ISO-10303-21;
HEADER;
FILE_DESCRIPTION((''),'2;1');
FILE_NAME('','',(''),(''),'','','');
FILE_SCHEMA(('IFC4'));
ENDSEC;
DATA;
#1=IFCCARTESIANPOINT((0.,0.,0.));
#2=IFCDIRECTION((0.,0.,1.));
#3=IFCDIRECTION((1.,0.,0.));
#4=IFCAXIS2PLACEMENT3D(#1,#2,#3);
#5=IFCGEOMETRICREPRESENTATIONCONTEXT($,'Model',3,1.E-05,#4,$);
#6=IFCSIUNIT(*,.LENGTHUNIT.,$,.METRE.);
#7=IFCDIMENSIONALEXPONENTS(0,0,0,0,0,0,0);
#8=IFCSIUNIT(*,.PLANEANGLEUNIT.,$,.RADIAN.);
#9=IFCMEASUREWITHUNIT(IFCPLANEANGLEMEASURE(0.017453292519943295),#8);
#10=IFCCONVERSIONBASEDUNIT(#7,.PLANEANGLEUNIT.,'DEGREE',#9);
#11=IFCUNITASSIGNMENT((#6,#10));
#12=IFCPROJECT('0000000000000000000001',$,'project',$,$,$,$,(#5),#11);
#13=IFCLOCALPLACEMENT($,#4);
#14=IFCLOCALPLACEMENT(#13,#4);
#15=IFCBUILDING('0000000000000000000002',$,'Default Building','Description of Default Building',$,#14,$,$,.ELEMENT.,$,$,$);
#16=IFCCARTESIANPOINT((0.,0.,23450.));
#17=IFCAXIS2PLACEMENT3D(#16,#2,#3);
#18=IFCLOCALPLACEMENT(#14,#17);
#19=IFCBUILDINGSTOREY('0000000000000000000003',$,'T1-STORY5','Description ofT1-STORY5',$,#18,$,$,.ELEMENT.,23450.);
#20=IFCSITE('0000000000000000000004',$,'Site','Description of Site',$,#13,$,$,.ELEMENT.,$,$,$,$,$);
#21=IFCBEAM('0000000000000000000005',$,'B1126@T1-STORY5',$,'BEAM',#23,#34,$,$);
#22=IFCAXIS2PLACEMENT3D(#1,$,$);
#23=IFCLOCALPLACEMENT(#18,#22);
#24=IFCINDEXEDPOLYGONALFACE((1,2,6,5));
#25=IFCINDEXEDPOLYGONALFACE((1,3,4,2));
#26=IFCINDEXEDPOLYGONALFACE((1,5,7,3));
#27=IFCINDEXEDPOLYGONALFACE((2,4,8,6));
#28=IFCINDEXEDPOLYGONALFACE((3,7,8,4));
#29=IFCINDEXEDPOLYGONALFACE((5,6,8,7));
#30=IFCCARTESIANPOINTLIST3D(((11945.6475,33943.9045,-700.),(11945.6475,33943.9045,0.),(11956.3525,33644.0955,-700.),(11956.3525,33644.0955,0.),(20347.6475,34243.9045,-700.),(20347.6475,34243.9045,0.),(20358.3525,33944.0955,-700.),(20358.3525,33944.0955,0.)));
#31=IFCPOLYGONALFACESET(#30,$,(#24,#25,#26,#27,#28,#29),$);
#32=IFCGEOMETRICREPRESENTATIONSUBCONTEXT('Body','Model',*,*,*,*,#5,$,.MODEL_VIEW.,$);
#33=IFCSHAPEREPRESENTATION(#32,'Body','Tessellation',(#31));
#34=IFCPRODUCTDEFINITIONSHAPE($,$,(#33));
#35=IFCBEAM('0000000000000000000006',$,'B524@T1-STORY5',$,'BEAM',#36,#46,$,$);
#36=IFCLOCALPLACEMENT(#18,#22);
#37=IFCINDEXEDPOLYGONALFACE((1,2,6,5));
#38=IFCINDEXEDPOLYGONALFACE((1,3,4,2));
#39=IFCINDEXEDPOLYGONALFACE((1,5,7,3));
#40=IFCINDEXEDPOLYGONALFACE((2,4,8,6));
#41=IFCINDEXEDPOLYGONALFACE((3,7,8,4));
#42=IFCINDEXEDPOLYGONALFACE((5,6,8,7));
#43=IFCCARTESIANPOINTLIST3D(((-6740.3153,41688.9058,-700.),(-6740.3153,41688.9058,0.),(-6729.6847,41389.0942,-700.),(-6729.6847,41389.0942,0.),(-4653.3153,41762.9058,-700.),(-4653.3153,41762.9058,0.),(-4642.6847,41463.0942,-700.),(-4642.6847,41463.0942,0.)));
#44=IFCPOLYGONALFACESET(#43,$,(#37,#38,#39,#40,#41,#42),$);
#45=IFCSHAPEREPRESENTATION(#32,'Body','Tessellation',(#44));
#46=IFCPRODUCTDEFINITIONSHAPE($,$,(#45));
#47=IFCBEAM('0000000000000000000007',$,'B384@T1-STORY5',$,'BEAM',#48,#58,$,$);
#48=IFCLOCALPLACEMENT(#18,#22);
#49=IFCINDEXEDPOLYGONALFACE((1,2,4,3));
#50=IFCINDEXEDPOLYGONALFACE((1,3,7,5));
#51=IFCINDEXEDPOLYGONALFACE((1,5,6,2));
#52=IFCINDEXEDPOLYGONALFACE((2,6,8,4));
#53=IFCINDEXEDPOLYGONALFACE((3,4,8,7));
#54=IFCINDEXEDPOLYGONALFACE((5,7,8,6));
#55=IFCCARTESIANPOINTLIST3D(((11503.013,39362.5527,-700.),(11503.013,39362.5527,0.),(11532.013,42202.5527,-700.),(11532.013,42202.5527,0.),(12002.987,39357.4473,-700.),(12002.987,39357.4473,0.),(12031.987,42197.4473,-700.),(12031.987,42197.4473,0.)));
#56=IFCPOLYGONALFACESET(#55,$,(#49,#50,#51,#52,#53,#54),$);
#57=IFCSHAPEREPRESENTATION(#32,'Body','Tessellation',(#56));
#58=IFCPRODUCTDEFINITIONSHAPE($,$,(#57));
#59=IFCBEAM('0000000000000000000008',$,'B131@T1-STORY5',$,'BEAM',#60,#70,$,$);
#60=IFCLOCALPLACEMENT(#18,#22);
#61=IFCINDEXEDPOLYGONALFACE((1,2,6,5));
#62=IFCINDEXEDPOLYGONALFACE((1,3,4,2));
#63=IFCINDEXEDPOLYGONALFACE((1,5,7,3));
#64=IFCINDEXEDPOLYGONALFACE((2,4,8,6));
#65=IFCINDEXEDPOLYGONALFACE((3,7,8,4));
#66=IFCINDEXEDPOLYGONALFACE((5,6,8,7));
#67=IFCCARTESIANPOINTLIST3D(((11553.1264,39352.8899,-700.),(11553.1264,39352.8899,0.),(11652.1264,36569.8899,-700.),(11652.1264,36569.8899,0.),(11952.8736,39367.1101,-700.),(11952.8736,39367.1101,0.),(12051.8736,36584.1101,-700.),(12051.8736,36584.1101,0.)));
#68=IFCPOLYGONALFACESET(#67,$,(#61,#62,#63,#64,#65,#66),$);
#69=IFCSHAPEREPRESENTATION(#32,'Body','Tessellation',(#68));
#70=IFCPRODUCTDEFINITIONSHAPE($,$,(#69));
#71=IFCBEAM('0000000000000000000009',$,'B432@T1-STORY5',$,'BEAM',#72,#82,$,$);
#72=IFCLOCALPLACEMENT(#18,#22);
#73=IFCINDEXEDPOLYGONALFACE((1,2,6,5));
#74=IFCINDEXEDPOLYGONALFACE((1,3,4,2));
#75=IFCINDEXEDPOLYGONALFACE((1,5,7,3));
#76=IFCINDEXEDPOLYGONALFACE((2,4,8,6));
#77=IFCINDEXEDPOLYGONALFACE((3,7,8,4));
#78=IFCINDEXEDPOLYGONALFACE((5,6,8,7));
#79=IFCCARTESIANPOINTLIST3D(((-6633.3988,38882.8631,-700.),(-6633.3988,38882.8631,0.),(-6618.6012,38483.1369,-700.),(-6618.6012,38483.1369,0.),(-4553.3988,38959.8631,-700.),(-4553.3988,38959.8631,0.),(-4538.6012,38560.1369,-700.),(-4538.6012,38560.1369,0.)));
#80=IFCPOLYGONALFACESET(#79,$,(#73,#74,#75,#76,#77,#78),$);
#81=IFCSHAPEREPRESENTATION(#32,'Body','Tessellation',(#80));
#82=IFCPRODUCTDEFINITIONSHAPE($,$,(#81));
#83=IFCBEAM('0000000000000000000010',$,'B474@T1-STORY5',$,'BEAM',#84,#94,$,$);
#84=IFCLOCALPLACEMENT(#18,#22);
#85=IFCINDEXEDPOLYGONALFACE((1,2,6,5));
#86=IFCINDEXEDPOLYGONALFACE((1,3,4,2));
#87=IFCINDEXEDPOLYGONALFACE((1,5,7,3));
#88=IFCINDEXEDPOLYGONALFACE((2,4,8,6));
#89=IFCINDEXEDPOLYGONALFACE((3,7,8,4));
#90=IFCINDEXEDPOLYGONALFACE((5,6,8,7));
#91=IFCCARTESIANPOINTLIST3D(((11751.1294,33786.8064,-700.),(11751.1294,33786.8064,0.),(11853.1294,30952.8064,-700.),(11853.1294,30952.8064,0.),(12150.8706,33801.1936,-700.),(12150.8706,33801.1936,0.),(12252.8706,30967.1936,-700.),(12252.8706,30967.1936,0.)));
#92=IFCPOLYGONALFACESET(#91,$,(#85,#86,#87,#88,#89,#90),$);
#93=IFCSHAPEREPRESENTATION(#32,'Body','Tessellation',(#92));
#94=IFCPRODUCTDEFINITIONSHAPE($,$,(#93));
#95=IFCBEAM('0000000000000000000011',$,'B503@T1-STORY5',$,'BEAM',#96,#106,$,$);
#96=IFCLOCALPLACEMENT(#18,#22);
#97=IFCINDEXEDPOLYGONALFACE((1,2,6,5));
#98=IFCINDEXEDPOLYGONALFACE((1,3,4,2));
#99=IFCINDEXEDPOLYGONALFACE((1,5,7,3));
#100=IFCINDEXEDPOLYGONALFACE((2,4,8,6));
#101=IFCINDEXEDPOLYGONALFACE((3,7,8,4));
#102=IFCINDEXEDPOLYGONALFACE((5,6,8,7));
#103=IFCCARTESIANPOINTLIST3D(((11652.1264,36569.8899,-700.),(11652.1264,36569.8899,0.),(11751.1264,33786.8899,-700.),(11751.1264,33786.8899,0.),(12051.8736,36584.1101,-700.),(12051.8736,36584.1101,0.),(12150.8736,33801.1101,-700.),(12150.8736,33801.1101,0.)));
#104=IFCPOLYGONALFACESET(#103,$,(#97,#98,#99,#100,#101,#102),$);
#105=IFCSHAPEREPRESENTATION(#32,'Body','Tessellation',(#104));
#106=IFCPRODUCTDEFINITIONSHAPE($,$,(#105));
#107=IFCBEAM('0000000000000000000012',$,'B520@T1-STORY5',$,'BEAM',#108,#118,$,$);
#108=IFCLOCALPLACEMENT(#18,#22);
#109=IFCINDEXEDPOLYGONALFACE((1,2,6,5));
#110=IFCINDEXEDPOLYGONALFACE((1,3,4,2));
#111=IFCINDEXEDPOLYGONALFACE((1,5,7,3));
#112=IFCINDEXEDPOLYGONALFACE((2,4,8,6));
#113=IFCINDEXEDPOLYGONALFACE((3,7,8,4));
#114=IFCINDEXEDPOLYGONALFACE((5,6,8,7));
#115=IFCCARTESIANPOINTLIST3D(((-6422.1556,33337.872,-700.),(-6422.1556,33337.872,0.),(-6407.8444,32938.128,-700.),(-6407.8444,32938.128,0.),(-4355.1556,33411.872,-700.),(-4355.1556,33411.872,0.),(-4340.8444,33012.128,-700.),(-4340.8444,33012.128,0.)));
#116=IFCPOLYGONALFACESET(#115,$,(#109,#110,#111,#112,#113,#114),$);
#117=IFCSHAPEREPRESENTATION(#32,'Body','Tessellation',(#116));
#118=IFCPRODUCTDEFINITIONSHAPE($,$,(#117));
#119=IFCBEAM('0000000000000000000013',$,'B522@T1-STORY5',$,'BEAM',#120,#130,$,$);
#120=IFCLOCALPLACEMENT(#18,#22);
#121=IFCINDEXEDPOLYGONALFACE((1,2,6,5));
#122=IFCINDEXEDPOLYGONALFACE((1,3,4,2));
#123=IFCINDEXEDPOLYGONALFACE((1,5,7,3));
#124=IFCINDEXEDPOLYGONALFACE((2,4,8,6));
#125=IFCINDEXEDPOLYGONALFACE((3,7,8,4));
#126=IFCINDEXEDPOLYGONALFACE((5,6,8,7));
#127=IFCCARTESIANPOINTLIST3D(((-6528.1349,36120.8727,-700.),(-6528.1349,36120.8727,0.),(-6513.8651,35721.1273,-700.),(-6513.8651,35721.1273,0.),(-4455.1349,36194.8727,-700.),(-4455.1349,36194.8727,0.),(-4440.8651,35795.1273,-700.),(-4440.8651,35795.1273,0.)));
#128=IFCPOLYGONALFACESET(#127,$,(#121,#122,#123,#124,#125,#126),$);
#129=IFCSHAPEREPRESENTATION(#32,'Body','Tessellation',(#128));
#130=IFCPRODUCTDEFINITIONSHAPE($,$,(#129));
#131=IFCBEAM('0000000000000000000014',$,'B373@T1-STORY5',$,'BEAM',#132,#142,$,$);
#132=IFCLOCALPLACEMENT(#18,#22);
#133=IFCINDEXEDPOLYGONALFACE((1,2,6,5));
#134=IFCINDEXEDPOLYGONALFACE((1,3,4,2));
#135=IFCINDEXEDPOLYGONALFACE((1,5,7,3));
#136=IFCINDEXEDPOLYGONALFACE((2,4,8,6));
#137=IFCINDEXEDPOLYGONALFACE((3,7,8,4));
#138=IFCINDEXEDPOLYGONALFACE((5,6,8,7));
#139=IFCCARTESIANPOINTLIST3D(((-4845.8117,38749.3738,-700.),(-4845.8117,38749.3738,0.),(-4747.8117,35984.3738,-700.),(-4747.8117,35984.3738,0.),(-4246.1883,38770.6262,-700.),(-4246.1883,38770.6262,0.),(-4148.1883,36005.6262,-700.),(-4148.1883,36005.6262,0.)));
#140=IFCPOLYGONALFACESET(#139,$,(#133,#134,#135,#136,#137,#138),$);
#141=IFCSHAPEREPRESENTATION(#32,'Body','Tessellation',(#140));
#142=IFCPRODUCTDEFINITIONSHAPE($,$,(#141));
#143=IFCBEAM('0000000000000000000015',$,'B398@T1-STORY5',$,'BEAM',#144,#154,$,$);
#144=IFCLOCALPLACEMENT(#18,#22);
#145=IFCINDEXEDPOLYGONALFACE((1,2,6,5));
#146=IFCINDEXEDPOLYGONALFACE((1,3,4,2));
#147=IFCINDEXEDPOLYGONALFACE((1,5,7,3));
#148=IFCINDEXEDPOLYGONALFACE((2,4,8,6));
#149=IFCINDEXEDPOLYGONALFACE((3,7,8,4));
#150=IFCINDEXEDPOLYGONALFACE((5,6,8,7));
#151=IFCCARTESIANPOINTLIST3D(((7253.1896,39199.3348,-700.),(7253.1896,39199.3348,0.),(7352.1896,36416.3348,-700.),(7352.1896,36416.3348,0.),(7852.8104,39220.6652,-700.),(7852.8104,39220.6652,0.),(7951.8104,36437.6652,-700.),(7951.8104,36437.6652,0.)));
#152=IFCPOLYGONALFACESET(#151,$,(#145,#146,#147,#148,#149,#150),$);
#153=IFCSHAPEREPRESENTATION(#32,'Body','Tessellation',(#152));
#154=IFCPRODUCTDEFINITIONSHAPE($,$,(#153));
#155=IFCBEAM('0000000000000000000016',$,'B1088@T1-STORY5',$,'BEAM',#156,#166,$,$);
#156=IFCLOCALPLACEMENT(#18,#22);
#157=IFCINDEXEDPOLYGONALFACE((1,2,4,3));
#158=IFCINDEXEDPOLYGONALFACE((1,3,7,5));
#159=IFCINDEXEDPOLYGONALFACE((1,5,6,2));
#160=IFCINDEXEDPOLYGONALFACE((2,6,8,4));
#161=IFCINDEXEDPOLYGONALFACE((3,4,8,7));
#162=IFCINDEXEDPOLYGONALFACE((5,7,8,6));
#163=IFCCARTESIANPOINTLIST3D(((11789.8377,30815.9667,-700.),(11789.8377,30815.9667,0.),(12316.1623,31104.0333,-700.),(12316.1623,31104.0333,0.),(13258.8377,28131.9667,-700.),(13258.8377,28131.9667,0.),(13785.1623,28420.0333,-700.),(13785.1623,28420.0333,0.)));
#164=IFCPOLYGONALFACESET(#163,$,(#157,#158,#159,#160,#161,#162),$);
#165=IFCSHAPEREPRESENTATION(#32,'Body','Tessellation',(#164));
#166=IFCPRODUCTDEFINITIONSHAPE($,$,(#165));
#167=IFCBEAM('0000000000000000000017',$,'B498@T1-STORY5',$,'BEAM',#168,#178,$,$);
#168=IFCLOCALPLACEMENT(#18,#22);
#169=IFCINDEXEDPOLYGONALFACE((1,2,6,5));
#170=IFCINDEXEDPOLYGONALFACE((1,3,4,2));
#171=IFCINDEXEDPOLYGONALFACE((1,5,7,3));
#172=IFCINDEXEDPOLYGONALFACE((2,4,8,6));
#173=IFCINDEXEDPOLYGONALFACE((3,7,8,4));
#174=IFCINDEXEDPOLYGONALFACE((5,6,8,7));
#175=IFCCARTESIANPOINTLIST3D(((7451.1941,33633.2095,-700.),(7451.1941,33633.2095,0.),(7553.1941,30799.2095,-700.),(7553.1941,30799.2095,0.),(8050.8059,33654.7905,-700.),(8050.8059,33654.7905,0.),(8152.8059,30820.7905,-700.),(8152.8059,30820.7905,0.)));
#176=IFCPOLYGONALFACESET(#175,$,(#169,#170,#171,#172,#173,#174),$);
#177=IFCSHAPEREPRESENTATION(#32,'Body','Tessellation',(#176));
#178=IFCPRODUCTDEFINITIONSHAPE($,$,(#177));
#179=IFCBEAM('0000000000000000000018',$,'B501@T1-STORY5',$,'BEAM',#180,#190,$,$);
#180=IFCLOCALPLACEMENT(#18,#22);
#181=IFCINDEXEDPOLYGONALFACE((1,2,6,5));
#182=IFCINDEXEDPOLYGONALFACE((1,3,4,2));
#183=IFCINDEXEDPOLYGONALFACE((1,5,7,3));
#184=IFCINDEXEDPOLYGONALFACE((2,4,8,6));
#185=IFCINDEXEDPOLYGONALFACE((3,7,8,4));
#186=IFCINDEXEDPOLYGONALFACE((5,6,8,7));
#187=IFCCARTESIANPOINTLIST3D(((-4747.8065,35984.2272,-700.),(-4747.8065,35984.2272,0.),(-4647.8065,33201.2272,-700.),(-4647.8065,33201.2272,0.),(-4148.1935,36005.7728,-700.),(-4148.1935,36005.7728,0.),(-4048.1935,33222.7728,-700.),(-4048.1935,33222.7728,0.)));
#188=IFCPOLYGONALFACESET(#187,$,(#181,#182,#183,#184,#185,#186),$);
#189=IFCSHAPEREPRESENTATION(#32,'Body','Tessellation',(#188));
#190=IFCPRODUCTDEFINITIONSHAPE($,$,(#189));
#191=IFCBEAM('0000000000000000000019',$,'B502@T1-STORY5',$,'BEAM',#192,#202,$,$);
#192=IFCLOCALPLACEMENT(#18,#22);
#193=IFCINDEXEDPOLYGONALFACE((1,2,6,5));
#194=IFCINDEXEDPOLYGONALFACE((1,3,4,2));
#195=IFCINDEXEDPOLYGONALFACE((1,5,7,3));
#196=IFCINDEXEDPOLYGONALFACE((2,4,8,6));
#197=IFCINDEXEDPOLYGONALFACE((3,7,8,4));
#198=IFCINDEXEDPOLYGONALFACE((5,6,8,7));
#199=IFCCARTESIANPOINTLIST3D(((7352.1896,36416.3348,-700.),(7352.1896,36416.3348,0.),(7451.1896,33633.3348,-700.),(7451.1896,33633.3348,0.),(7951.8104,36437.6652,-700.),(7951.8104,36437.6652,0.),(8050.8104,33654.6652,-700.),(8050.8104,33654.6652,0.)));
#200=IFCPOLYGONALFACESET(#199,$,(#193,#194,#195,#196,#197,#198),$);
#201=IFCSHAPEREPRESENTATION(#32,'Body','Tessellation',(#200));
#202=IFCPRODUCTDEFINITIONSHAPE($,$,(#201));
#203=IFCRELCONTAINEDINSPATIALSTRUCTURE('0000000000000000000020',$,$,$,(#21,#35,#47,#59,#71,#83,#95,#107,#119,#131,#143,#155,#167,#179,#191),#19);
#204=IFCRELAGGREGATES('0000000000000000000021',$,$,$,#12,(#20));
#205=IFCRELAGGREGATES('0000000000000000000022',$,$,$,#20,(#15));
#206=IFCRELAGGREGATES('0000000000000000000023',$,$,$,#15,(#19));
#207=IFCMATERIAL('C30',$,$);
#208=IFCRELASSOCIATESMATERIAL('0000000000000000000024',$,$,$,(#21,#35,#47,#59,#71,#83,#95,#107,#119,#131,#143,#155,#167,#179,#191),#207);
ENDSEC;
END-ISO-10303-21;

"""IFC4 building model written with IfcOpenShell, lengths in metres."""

from ifc_helpers import new_model, entity, si_unit, converted_unit, frame, origin_with_axes, place, context, subcontext, project, spatial, rectangle, extrude, material, element, save


model = new_model("IFC4")

# Units and contexts
model_context = context("Model", 3, precision=1e-05, world=origin_with_axes())
body_context = subcontext(model_context, "Body", "Model", "MODEL_VIEW")
ifc_project = project(units=[si_unit("LENGTHUNIT", "METRE"), converted_unit("PLANEANGLEUNIT", "DEGREE", entity("IfcPlaneAngleMeasure", 0.017453292519943295), si_unit("PLANEANGLEUNIT", "RADIAN"), dimensions=[0, 0, 0, 0, 0, 0, 0])], contexts=[model_context])

# Site, building, storey
site_placement = place(None, origin_with_axes())
site = spatial("IfcSite", under=ifc_project, at=site_placement, Name="Site", Description="Description of Site", CompositionType="ELEMENT")
building_placement = place(site_placement, origin_with_axes())
building = spatial("IfcBuilding", under=site, at=building_placement, Name="Default Building", Description="Description of Default Building", CompositionType="ELEMENT")
storey_placement = place(building_placement, frame((0.0, 0.0, 23450.0), z_axis=(0.0, 0.0, 1.0), x_axis=(1.0, 0.0, 0.0)))
storey = spatial("IfcBuildingStorey", under=building, at=storey_placement, Name="T1-STORY5", Description="Description ofT1-STORY5", CompositionType="ELEMENT", Elevation=23450.0)

# Beams
ifc_material_1 = material(Name="C30")
beam_1_placement = place(storey_placement, frame((11951.0, 33794.0, -350.0), z_axis=(0.999363, 0.035683, 0.0), x_axis=(-0.035683, 0.999363, 0.0)))
element("IfcBeam", 1, at=beam_1_placement, inside=storey, material=ifc_material_1, Name="B1126@T1-STORY5", ObjectType="BEAM", context=body_context, shape_type="SweptSolid", body=[
    extrude(rectangle(XDim=300.0, YDim=700.0), origin_with_axes(), (0.0, 0.0, 1.0), 8407.3542),
])
beam_2_placement = place(storey_placement, frame((-6735.0, 41539.0, -350.0), z_axis=(0.999372, 0.035435, 0.0), x_axis=(-0.035435, 0.999372, 0.0)))
element("IfcBeam", 2, at=beam_2_placement, inside=storey, material=ifc_material_1, Name="B524@T1-STORY5", ObjectType="BEAM", context=body_context, shape_type="SweptSolid", body=[
    extrude(rectangle(XDim=300.0, YDim=700.0), origin_with_axes(), (0.0, 0.0, 1.0), 2088.3115),
])
beam_3_placement = place(storey_placement, frame((11753.0, 39360.0, -350.0), z_axis=(0.010211, 0.999948, 0.0), x_axis=(-0.999948, 0.010211, 0.0)))
element("IfcBeam", 3, at=beam_3_placement, inside=storey, material=ifc_material_1, Name="B384@T1-STORY5", ObjectType="BEAM", context=body_context, shape_type="SweptSolid", body=[
    extrude(rectangle(XDim=500.0, YDim=700.0), origin_with_axes(), (0.0, 0.0, 1.0), 2840.1481),
])
beam_4_placement = place(storey_placement, frame((11753.0, 39360.0, -350.0), z_axis=(0.035551, -0.999368, 0.0), x_axis=(0.999368, 0.035551, 0.0)))
element("IfcBeam", 4, at=beam_4_placement, inside=storey, material=ifc_material_1, Name="B131@T1-STORY5", ObjectType="BEAM", context=body_context, shape_type="SweptSolid", body=[
    extrude(rectangle(XDim=400.0, YDim=700.0), origin_with_axes(), (0.0, 0.0, 1.0), 2784.7603),
])
beam_5_placement = place(storey_placement, frame((-6626.0, 38683.0, -350.0), z_axis=(0.999315, 0.036994, 0.0), x_axis=(-0.036994, 0.999315, 0.0)))
element("IfcBeam", 5, at=beam_5_placement, inside=storey, material=ifc_material_1, Name="B432@T1-STORY5", ObjectType="BEAM", context=body_context, shape_type="SweptSolid", body=[
    extrude(rectangle(XDim=400.0, YDim=700.0), origin_with_axes(), (0.0, 0.0, 1.0), 2081.4248),
])
beam_6_placement = place(storey_placement, frame((11951.0, 33794.0, -350.0), z_axis=(0.035968, -0.999353, 0.0), x_axis=(0.999353, 0.035968, 0.0)))
element("IfcBeam", 6, at=beam_6_placement, inside=storey, material=ifc_material_1, Name="B474@T1-STORY5", ObjectType="BEAM", context=body_context, shape_type="SweptSolid", body=[
    extrude(rectangle(XDim=400.0, YDim=700.0), origin_with_axes(), (0.0, 0.0, 1.0), 2835.835),
])
beam_7_placement = place(storey_placement, frame((11852.0, 36577.0, -350.0), z_axis=(0.035551, -0.999368, 0.0), x_axis=(0.999368, 0.035551, 0.0)))
element("IfcBeam", 7, at=beam_7_placement, inside=storey, material=ifc_material_1, Name="B503@T1-STORY5", ObjectType="BEAM", context=body_context, shape_type="SweptSolid", body=[
    extrude(rectangle(XDim=400.0, YDim=700.0), origin_with_axes(), (0.0, 0.0, 1.0), 2784.7603),
])
beam_8_placement = place(storey_placement, frame((-6415.0, 33138.0, -350.0), z_axis=(0.99936, 0.035778, 0.0), x_axis=(-0.035778, 0.99936, 0.0)))
element("IfcBeam", 8, at=beam_8_placement, inside=storey, material=ifc_material_1, Name="B520@T1-STORY5", ObjectType="BEAM", context=body_context, shape_type="SweptSolid", body=[
    extrude(rectangle(XDim=400.0, YDim=700.0), origin_with_axes(), (0.0, 0.0, 1.0), 2068.3242),
])
beam_9_placement = place(storey_placement, frame((-6521.0, 35921.0, -350.0), z_axis=(0.999363, 0.035674, 0.0), x_axis=(-0.035674, 0.999363, 0.0)))
element("IfcBeam", 9, at=beam_9_placement, inside=storey, material=ifc_material_1, Name="B522@T1-STORY5", ObjectType="BEAM", context=body_context, shape_type="SweptSolid", body=[
    extrude(rectangle(XDim=400.0, YDim=700.0), origin_with_axes(), (0.0, 0.0, 1.0), 2074.3204),
])
beam_10_placement = place(storey_placement, frame((-4546.0, 38760.0, -350.0), z_axis=(0.035421, -0.999372, 0.0), x_axis=(0.999372, 0.035421, 0.0)))
element("IfcBeam", 10, at=beam_10_placement, inside=storey, material=ifc_material_1, Name="B373@T1-STORY5", ObjectType="BEAM", context=body_context, shape_type="SweptSolid", body=[
    extrude(rectangle(XDim=600.0, YDim=700.0), origin_with_axes(), (0.0, 0.0, 1.0), 2766.7362),
])
beam_11_placement = place(storey_placement, frame((7553.0, 39210.0, -350.0), z_axis=(0.035551, -0.999368, 0.0), x_axis=(0.999368, 0.035551, 0.0)))
element("IfcBeam", 11, at=beam_11_placement, inside=storey, material=ifc_material_1, Name="B398@T1-STORY5", ObjectType="BEAM", context=body_context, shape_type="SweptSolid", body=[
    extrude(rectangle(XDim=600.0, YDim=700.0), origin_with_axes(), (0.0, 0.0, 1.0), 2784.7603),
])
beam_12_placement = place(storey_placement, frame((12053.0, 30960.0, -350.0), z_axis=(0.480111, -0.877208, 0.0), x_axis=(0.877208, 0.480111, 0.0)))
element("IfcBeam", 12, at=beam_12_placement, inside=storey, material=ifc_material_1, Name="B1088@T1-STORY5", ObjectType="BEAM", context=body_context, shape_type="SweptSolid", body=[
    extrude(rectangle(XDim=600.0, YDim=700.0), origin_with_axes(), (0.0, 0.0, 1.0), 3059.7086),
])
beam_13_placement = place(storey_placement, frame((7751.0, 33644.0, -350.0), z_axis=(0.035968, -0.999353, 0.0), x_axis=(0.999353, 0.035968, 0.0)))
element("IfcBeam", 13, at=beam_13_placement, inside=storey, material=ifc_material_1, Name="B498@T1-STORY5", ObjectType="BEAM", context=body_context, shape_type="SweptSolid", body=[
    extrude(rectangle(XDim=600.0, YDim=700.0), origin_with_axes(), (0.0, 0.0, 1.0), 2835.835),
])
beam_14_placement = place(storey_placement, frame((-4448.0, 35995.0, -350.0), z_axis=(0.035909, -0.999355, 0.0), x_axis=(0.999355, 0.035909, 0.0)))
element("IfcBeam", 14, at=beam_14_placement, inside=storey, material=ifc_material_1, Name="B501@T1-STORY5", ObjectType="BEAM", context=body_context, shape_type="SweptSolid", body=[
    extrude(rectangle(XDim=600.0, YDim=700.0), origin_with_axes(), (0.0, 0.0, 1.0), 2784.796),
])
beam_15_placement = place(storey_placement, frame((7652.0, 36427.0, -350.0), z_axis=(0.035551, -0.999368, 0.0), x_axis=(0.999368, 0.035551, 0.0)))
element("IfcBeam", 15, at=beam_15_placement, inside=storey, material=ifc_material_1, Name="B502@T1-STORY5", ObjectType="BEAM", context=body_context, shape_type="SweptSolid", body=[
    extrude(rectangle(XDim=600.0, YDim=700.0), origin_with_axes(), (0.0, 0.0, 1.0), 2784.7603),
])

save(model, "model.ifc")
